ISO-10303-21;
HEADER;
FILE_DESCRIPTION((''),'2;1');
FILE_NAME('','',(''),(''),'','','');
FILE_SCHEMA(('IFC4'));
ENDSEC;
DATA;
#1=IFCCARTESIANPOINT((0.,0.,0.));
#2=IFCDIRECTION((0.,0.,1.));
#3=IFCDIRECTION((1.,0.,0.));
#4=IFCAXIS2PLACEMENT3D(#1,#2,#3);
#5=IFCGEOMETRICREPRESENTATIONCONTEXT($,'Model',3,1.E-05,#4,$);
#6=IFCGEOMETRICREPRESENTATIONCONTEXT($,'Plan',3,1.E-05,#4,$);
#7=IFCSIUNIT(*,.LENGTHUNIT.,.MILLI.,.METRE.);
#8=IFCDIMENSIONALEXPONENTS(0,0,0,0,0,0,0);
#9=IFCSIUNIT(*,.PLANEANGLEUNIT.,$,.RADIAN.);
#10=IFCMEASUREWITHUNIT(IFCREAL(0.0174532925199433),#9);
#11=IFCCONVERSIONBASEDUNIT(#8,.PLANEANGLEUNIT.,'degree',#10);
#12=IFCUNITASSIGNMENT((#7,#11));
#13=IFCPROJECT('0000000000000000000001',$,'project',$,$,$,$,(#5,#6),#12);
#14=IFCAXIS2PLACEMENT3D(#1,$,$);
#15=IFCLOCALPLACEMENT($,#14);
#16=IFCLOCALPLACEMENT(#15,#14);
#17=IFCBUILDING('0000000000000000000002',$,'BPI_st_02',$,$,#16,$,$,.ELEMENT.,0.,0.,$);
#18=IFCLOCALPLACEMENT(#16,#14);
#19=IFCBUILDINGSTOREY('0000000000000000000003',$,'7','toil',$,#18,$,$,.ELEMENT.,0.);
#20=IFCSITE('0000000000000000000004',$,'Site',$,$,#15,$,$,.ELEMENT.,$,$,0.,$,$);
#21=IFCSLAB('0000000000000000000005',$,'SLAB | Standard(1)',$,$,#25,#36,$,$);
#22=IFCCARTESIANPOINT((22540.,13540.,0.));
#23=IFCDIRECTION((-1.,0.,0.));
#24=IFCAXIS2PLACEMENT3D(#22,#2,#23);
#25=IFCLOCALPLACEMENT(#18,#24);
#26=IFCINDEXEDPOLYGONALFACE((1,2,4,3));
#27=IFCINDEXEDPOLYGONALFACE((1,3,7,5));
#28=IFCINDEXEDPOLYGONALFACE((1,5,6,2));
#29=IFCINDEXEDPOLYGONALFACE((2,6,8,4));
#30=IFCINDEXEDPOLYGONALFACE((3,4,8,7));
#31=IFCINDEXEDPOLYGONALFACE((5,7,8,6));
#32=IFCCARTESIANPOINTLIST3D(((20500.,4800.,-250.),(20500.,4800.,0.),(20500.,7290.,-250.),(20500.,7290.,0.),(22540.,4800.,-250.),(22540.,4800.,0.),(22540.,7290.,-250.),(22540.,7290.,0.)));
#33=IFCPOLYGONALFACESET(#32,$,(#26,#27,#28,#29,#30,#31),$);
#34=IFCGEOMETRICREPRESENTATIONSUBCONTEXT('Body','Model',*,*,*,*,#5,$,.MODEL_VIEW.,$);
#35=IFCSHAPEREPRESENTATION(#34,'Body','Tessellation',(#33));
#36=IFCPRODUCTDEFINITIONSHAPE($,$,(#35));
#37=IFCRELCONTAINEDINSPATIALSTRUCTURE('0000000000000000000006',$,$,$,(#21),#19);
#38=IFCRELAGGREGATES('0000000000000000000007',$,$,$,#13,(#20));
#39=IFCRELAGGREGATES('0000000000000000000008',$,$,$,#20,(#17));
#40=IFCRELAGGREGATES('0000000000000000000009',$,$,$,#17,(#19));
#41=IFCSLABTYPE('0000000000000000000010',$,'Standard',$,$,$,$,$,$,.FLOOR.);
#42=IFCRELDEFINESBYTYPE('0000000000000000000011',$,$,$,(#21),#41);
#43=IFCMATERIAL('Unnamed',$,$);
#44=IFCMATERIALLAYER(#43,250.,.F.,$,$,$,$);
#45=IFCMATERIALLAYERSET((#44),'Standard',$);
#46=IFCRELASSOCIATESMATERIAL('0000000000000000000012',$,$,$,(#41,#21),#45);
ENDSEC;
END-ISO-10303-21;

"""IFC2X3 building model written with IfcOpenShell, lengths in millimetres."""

from ifc_helpers import new_model, entity, si_unit, converted_unit, frame, frame_2d, origin, origin_with_axes, place, context, subcontext, project, spatial, rectangle, extrude, material, layer, layer_set, layer_usage, type_object, element, save


model = new_model("IFC2X3")

# Units and contexts
model_context = context("Model", 3, precision=1e-05, world=origin_with_axes())
plan_context = context("Plan", 3, precision=1e-05, world=origin_with_axes())
body_context = subcontext(model_context, "Body", "Model", "MODEL_VIEW")
ifc_project = project(units=[si_unit("LENGTHUNIT", "METRE", prefix="MILLI"), converted_unit("PLANEANGLEUNIT", "degree", entity("IfcReal", 0.0174532925199433), si_unit("PLANEANGLEUNIT", "RADIAN"), dimensions=[0, 0, 0, 0, 0, 0, 0])], contexts=[model_context, plan_context])

# Site, building, storey
site_placement = place(None, origin())
site = spatial("IfcSite", under=ifc_project, at=site_placement, Name="Site", CompositionType="ELEMENT", RefElevation=0.0)
building_placement = place(site_placement, origin())
building = spatial("IfcBuilding", under=site, at=building_placement, Name="BPI_st_02", CompositionType="ELEMENT", ElevationOfRefHeight=0.0, ElevationOfTerrain=0.0)
storey_placement = place(building_placement, origin())
storey = spatial("IfcBuildingStorey", under=building, at=storey_placement, Name="7", Description="toil", CompositionType="ELEMENT", Elevation=0.0)

# Slab
ifc_material = material(Name="Unnamed")
ifc_layer_1 = layer(ifc_material, 250.0, ventilated=False)
ifc_layer_set_1 = layer_set([ifc_layer_1], Name="Standard")
ifc_layer_usage_1 = layer_usage(ifc_layer_set_1, "AXIS3", "POSITIVE", 0.0)
slab_type = type_object("IfcSlabType", Name="Standard", PredefinedType="FLOOR", material=ifc_layer_set_1)
slab_placement = place(storey_placement, frame((22540.0, 13540.0, 0.0), z_axis=(0.0, 0.0, 1.0), x_axis=(-1.0, 0.0, 0.0)))
element("IfcSlab", 1, at=slab_placement, inside=storey, type_object=slab_type, material=ifc_layer_usage_1, Name="SLAB | Standard(1)", context=body_context, shape_type="SweptSolid", body=[
    extrude(rectangle(XDim=2040.0, YDim=2490.0, at=frame_2d((21520.0, 6045.0), x_axis=(1.0, 0.0))), frame((0.0, 0.0, -250.0)), (0.0, 0.0, 1.0), 250.0),
])

save(model, "model.ifc")
